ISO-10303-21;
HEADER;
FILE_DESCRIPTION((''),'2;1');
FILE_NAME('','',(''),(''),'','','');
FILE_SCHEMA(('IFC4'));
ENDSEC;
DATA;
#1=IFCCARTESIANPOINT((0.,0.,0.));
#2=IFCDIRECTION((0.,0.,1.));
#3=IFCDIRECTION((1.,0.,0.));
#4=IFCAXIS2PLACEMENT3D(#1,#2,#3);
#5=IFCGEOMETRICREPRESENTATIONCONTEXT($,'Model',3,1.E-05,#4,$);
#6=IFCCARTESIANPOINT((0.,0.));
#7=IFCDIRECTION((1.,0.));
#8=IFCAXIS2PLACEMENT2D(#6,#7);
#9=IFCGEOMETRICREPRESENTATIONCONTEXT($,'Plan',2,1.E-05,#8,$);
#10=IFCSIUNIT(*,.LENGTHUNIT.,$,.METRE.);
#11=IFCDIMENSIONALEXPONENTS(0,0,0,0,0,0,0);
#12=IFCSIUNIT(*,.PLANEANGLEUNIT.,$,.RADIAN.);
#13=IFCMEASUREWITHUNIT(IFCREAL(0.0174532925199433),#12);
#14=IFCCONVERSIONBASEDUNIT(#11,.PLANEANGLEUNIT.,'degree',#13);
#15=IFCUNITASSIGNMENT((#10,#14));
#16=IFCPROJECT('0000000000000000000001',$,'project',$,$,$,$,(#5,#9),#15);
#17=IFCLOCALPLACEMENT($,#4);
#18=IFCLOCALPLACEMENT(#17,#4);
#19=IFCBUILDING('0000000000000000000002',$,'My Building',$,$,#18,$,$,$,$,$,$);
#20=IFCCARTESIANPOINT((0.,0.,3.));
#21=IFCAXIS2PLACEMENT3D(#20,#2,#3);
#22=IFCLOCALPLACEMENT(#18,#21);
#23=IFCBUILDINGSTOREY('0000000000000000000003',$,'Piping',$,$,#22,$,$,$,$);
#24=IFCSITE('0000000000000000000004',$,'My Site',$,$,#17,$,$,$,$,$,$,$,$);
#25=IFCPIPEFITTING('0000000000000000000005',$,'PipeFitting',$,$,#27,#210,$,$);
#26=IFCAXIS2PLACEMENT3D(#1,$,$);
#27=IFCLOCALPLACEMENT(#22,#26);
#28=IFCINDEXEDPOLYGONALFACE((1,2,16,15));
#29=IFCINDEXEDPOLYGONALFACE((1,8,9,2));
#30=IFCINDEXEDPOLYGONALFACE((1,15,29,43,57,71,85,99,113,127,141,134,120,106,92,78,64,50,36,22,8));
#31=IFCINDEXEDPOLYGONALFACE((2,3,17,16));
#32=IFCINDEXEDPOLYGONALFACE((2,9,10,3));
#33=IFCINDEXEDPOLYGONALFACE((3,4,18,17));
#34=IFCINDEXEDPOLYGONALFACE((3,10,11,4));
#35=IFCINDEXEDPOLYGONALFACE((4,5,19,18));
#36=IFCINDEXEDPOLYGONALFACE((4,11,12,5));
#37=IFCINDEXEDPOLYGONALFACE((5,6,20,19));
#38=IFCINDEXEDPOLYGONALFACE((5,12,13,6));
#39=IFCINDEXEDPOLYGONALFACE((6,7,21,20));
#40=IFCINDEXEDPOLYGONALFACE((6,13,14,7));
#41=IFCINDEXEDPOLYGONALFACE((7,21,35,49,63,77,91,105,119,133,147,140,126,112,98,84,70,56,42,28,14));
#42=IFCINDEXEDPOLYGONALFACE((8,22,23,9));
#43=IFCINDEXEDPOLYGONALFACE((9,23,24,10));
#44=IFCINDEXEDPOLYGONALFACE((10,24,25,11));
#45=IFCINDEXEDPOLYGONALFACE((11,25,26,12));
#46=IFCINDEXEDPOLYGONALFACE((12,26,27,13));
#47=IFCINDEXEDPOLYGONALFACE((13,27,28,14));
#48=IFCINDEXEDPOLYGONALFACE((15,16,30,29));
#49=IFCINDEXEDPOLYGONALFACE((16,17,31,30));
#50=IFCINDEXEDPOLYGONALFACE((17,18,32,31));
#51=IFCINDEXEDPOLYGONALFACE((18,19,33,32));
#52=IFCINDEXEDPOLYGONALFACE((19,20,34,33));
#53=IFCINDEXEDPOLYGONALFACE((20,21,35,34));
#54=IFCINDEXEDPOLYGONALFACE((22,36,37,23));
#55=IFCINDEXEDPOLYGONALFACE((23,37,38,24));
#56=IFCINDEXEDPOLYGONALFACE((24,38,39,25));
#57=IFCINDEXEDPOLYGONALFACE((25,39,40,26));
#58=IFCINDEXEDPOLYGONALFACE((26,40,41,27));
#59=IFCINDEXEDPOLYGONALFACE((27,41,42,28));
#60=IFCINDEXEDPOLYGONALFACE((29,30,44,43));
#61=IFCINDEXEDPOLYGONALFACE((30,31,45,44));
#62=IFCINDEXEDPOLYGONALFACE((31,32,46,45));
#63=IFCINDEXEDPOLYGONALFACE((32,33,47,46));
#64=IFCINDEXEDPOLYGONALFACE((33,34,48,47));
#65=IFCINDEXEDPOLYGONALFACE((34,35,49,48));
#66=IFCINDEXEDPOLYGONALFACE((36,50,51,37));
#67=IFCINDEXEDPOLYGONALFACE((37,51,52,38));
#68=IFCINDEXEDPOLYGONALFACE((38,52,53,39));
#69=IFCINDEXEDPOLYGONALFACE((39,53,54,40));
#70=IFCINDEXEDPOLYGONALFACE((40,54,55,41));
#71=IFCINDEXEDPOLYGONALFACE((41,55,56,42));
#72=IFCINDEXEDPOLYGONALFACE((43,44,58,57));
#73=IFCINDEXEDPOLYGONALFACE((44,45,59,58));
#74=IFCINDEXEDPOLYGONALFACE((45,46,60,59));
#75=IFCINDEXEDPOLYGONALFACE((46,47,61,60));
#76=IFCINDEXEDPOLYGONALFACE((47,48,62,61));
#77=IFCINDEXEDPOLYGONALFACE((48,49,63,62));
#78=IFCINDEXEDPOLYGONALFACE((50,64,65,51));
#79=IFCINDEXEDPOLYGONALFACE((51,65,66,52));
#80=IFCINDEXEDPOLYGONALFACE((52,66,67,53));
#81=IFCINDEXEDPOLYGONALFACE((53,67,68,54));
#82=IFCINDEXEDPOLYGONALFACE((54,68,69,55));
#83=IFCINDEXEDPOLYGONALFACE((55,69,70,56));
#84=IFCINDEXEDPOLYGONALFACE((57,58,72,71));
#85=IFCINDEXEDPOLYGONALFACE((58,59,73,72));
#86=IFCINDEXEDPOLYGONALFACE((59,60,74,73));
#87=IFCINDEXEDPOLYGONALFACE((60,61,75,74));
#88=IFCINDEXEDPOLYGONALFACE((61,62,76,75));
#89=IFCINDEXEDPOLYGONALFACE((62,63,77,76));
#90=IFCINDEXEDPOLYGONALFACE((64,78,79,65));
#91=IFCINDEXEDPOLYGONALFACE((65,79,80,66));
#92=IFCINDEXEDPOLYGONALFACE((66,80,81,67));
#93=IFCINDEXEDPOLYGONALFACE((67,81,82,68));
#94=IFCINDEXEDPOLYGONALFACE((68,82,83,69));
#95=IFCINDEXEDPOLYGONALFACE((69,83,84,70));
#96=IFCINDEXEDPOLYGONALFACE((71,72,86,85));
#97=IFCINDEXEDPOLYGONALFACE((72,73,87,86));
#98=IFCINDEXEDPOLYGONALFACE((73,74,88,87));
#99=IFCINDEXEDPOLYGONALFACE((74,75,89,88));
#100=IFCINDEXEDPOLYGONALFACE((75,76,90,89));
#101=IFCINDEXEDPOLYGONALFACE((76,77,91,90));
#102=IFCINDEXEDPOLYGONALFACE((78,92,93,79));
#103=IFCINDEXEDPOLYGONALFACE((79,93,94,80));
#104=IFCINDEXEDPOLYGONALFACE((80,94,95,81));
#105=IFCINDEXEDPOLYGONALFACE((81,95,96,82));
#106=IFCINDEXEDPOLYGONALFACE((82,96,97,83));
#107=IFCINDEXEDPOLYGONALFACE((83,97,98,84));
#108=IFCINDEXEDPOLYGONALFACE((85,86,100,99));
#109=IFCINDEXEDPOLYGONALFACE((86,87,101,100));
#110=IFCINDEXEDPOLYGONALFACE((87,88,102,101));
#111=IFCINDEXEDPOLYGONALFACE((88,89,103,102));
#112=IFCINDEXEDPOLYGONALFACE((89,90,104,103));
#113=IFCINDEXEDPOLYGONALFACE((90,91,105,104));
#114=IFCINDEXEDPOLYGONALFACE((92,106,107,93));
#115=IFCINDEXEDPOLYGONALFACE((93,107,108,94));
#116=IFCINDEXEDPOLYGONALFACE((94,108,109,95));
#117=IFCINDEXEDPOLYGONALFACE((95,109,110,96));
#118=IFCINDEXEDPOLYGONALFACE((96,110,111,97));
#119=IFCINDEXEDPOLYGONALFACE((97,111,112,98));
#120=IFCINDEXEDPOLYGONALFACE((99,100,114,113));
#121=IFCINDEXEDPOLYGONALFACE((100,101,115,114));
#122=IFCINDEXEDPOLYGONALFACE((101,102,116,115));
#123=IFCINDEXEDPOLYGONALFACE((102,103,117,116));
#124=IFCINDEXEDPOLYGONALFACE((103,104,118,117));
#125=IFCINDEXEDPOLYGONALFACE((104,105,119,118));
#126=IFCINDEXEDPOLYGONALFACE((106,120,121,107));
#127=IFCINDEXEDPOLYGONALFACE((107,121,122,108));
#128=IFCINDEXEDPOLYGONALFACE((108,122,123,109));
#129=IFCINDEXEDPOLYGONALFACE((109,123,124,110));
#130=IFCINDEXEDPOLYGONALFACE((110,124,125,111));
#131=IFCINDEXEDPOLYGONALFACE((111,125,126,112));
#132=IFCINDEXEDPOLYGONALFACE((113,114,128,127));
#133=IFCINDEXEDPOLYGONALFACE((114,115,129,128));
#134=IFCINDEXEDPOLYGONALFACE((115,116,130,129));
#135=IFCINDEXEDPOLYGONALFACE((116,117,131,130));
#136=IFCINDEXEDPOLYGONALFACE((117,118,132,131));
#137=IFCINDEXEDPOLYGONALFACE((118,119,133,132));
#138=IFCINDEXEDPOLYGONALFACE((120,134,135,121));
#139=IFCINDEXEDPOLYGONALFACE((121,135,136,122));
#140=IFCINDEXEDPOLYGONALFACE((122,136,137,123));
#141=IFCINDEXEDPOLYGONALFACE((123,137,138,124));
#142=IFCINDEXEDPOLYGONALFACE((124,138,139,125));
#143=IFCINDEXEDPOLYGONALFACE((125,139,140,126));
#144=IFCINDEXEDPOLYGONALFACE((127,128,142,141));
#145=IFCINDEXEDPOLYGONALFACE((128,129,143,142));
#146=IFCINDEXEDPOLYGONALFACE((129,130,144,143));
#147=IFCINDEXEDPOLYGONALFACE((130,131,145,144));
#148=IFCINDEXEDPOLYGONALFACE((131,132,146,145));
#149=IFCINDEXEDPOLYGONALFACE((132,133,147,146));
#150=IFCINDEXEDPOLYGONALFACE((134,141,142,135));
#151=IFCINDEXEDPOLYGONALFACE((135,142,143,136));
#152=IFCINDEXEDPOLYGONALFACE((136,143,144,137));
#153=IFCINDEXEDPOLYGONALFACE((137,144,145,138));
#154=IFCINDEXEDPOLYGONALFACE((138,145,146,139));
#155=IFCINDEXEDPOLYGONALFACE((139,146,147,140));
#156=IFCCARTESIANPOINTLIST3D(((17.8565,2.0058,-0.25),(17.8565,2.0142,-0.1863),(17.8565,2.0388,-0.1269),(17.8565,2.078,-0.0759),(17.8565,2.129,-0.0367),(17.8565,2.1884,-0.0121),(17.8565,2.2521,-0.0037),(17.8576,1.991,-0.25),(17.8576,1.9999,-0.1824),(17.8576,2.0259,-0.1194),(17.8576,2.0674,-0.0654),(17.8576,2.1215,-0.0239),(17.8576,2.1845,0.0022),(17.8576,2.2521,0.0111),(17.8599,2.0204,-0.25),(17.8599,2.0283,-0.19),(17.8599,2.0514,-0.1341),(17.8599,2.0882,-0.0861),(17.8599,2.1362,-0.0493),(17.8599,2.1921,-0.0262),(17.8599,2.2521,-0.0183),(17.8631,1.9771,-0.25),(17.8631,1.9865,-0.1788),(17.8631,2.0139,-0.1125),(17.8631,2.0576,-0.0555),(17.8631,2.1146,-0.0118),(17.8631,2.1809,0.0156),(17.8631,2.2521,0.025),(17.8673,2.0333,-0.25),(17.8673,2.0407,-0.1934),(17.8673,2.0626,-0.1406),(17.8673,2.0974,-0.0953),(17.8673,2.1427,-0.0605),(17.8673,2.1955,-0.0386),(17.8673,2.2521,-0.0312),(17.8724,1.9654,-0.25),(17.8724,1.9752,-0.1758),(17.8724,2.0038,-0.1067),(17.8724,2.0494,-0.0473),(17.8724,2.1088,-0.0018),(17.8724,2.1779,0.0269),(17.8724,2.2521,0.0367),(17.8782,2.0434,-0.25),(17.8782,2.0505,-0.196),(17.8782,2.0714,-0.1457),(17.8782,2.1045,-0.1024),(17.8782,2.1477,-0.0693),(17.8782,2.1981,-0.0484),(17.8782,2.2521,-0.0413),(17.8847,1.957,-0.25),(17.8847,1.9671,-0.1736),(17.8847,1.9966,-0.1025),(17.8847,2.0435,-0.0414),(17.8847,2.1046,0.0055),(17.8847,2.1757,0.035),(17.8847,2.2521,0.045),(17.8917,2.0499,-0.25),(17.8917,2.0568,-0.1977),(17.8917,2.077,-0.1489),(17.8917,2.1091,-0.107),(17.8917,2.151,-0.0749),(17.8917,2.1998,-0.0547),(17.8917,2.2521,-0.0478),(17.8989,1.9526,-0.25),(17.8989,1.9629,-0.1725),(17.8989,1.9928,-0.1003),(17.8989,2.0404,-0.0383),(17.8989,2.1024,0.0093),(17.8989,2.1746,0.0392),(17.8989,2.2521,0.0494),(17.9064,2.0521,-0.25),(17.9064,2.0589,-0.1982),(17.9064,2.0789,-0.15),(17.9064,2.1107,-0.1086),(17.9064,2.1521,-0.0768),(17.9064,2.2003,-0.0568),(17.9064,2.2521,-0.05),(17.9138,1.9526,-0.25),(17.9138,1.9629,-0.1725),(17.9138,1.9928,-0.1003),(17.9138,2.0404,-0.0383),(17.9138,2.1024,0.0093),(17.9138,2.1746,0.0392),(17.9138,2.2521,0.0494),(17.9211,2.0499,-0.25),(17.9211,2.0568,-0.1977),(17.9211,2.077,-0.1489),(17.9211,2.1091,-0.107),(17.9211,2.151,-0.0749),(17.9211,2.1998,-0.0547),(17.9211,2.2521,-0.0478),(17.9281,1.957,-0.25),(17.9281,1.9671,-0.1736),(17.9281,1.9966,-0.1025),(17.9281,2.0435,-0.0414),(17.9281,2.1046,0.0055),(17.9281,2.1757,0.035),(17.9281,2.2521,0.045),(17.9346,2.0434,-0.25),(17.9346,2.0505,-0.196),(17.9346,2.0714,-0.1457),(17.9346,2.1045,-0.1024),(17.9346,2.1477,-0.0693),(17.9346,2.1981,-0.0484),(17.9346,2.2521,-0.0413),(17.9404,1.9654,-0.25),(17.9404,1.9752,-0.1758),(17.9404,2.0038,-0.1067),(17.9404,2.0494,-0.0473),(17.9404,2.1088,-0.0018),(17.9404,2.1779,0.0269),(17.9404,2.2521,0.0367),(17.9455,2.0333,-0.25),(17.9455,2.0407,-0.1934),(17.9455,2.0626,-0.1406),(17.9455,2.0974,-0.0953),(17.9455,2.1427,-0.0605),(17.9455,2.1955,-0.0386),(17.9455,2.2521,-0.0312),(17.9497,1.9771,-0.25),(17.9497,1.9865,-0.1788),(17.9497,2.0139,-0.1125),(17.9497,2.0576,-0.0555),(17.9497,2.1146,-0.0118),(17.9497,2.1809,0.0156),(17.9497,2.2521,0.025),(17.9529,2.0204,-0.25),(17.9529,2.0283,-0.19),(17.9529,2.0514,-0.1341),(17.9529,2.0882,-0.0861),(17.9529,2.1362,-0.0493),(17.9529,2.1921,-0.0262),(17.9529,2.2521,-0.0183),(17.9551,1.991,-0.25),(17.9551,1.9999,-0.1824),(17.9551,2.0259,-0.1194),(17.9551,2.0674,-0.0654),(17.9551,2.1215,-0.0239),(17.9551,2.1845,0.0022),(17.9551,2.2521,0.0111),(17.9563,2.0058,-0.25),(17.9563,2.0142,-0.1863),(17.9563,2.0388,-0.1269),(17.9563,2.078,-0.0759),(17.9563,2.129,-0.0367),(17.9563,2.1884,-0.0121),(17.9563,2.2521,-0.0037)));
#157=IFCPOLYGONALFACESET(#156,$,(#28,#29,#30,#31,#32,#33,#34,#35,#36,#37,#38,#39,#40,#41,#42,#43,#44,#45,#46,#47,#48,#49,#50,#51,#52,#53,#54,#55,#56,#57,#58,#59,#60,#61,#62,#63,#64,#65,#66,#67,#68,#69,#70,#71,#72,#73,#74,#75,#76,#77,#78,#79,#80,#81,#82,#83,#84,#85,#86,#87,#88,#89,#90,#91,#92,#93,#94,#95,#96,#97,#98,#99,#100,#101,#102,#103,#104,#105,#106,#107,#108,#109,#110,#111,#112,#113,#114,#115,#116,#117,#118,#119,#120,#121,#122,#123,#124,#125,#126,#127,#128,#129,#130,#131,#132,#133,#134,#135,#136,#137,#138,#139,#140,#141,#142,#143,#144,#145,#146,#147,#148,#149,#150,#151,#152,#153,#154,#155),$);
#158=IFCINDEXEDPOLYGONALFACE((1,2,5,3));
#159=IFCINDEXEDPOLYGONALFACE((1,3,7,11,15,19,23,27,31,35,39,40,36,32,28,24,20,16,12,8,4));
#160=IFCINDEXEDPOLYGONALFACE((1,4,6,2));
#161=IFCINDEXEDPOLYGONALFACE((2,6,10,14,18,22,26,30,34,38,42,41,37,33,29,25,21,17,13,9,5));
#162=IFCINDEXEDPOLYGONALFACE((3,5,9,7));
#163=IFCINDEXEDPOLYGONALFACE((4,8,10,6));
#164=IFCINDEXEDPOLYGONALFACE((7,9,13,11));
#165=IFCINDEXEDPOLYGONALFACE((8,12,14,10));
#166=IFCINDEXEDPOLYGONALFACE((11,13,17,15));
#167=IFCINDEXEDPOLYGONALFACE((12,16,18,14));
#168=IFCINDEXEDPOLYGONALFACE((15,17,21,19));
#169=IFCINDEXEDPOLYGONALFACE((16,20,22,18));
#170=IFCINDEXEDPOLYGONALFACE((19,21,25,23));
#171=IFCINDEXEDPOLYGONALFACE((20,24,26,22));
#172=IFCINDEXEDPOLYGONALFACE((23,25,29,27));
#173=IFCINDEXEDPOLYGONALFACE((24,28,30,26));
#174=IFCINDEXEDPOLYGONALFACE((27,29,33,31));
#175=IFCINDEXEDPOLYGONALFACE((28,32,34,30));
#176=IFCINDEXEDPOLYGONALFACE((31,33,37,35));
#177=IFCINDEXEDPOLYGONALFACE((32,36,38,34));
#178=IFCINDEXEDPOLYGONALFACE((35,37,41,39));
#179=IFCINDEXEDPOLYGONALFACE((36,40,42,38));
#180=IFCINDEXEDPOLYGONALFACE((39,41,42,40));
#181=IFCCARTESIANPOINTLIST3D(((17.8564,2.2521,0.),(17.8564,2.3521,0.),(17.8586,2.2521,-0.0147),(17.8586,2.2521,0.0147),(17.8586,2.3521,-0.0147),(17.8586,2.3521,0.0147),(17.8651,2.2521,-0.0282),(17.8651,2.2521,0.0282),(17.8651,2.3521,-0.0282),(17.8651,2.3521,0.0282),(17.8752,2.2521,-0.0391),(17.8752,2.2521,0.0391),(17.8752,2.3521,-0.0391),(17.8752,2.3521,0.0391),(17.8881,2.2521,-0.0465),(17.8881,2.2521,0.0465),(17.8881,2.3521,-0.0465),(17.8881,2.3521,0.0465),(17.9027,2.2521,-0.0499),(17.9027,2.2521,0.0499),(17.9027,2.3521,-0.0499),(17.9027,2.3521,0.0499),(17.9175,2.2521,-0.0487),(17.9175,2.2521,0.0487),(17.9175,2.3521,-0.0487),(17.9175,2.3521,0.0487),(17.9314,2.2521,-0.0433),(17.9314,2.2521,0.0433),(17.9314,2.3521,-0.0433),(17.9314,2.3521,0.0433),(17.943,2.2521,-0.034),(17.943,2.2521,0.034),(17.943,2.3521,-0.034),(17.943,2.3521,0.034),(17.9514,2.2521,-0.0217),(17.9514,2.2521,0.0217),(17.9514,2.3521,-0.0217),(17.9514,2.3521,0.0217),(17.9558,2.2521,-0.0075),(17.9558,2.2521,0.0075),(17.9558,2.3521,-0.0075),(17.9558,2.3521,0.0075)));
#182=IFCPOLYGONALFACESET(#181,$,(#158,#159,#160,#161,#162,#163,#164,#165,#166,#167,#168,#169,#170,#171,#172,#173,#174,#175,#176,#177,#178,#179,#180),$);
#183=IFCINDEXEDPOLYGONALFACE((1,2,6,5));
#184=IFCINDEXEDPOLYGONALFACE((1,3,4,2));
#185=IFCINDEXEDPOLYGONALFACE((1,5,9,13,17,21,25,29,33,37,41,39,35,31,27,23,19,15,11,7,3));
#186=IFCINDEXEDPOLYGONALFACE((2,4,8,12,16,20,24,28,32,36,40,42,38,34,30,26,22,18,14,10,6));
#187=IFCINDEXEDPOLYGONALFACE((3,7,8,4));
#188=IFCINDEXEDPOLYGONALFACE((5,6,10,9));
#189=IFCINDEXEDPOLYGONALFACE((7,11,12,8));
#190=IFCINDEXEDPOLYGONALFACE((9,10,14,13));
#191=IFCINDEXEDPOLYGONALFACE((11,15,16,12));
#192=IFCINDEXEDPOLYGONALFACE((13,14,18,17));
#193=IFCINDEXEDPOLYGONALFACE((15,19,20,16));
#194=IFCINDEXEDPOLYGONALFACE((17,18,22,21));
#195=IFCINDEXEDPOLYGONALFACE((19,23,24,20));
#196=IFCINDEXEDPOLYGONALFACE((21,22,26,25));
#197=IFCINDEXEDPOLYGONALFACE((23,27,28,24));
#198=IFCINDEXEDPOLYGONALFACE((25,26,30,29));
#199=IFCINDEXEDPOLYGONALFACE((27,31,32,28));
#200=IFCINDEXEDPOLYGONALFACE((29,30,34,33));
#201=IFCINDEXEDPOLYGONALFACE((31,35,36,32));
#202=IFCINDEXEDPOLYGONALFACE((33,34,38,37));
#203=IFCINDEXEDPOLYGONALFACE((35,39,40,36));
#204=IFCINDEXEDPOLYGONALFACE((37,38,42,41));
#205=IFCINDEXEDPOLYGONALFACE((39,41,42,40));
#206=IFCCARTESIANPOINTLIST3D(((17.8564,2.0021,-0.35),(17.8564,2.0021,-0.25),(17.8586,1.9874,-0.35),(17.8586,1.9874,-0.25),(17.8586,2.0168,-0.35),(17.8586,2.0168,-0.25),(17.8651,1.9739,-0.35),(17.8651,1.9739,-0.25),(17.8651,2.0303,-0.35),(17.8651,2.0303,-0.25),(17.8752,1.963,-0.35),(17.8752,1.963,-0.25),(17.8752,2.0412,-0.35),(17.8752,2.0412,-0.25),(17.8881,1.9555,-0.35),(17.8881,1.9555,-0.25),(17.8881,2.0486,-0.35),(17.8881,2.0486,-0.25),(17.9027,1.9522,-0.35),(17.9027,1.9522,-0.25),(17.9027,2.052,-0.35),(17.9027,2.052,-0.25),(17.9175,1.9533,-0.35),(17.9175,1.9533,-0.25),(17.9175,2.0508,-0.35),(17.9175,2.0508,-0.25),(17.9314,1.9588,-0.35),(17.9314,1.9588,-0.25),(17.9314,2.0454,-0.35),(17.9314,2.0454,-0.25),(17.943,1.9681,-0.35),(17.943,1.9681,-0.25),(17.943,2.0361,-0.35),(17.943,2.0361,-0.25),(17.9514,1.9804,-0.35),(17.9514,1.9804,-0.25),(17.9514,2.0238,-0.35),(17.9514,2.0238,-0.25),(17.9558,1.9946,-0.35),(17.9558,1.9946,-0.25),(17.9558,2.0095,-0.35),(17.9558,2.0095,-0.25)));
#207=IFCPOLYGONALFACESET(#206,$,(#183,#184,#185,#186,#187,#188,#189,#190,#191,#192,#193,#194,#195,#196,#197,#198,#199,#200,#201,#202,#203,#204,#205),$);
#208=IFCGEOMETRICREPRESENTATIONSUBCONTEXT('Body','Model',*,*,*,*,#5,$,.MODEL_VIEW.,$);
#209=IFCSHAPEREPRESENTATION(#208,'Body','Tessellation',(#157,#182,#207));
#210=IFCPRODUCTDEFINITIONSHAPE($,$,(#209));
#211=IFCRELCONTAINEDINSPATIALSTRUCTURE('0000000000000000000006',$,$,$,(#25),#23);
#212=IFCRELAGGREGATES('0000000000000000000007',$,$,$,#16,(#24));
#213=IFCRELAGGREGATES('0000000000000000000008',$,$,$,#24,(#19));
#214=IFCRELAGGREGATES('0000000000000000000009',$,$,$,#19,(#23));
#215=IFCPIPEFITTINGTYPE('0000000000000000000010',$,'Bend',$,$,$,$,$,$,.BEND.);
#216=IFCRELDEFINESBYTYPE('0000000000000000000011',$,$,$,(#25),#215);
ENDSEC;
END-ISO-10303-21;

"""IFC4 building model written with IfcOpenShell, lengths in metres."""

from ifc_helpers import new_model, entity, si_unit, converted_unit, frame, origin_with_axes, origin_2d_with_axis, place, context, subcontext, project, spatial, circle, extrude, source, transform, mapped, type_object, type_shapes, element, save


model = new_model("IFC4")

# Units and contexts
model_context = context("Model", 3, precision=1e-05, world=origin_with_axes())
plan_context = context("Plan", 2, precision=1e-05, world=origin_2d_with_axis())
body_context = subcontext(model_context, "Body", "Model", "MODEL_VIEW")
ifc_project = project(units=[si_unit("LENGTHUNIT", "METRE"), converted_unit("PLANEANGLEUNIT", "degree", entity("IfcReal", 0.0174532925199433), si_unit("PLANEANGLEUNIT", "RADIAN"), dimensions=[0, 0, 0, 0, 0, 0, 0])], contexts=[model_context, plan_context])

# Site, building, storey
site_placement = place(None, origin_with_axes())
site = spatial("IfcSite", under=ifc_project, at=site_placement, Name="My Site")
building_placement = place(site_placement, origin_with_axes())
building = spatial("IfcBuilding", under=site, at=building_placement, Name="My Building")
storey_placement = place(building_placement, frame((0.0, 0.0, 3.0), z_axis=(0.0, 0.0, 1.0), x_axis=(1.0, 0.0, 0.0)))
storey = spatial("IfcBuildingStorey", under=building, at=storey_placement, Name="Piping")

# Pipe fitting
pipe_fitting_type_1 = type_object("IfcPipeFittingType", Name="Bend", PredefinedType="BEND")
shared_shape = source(origin_with_axes(), body_context, "Body", "SolidModel", [
    entity("IfcSweptDiskSolid", entity("IfcIndexedPolyCurve", entity("IfcCartesianPointList3D", [[0.0, 0.0, -0.1], [0.0, -0.0732, -0.2768], [0.0, -0.25, -0.35]]), [entity("IfcArcIndex", [1, 2, 3])]), 0.05),
    extrude(circle(Radius=0.05), origin_with_axes(), (0.0, 0.0, -1.0), 0.1),
    extrude(circle(Radius=0.05), frame((0.0, -0.25, -0.35), z_axis=(0.0, -1.0, 0.0), x_axis=(1.0, 0.0, 0.0)), (0.0, 0.0, 1.0), 0.1),
])
type_shapes(pipe_fitting_type_1, [shared_shape])
for number, where, z_axis, x_axis, name in (
    (1, (17.9064, 2.3521, 0.0), (0.0, 1.0, 0.0), (-1.0, 0.0, 0.0), "PipeFitting"),
):
    element("IfcPipeFitting", number, at=place(storey_placement, frame(where, z_axis=z_axis, x_axis=x_axis)), inside=storey, type_object=pipe_fitting_type_1, Name=name, context=body_context, shape_type="MappedRepresentation", body=[
        mapped(shared_shape, transform((0.0, 0.0, 0.0), x_axis=(1.0, 0.0, 0.0), y_axis=(0.0, 1.0, 0.0), z_axis=(0.0, 0.0, 1.0), scale=1.0)),
    ])

save(model, "model.ifc")
